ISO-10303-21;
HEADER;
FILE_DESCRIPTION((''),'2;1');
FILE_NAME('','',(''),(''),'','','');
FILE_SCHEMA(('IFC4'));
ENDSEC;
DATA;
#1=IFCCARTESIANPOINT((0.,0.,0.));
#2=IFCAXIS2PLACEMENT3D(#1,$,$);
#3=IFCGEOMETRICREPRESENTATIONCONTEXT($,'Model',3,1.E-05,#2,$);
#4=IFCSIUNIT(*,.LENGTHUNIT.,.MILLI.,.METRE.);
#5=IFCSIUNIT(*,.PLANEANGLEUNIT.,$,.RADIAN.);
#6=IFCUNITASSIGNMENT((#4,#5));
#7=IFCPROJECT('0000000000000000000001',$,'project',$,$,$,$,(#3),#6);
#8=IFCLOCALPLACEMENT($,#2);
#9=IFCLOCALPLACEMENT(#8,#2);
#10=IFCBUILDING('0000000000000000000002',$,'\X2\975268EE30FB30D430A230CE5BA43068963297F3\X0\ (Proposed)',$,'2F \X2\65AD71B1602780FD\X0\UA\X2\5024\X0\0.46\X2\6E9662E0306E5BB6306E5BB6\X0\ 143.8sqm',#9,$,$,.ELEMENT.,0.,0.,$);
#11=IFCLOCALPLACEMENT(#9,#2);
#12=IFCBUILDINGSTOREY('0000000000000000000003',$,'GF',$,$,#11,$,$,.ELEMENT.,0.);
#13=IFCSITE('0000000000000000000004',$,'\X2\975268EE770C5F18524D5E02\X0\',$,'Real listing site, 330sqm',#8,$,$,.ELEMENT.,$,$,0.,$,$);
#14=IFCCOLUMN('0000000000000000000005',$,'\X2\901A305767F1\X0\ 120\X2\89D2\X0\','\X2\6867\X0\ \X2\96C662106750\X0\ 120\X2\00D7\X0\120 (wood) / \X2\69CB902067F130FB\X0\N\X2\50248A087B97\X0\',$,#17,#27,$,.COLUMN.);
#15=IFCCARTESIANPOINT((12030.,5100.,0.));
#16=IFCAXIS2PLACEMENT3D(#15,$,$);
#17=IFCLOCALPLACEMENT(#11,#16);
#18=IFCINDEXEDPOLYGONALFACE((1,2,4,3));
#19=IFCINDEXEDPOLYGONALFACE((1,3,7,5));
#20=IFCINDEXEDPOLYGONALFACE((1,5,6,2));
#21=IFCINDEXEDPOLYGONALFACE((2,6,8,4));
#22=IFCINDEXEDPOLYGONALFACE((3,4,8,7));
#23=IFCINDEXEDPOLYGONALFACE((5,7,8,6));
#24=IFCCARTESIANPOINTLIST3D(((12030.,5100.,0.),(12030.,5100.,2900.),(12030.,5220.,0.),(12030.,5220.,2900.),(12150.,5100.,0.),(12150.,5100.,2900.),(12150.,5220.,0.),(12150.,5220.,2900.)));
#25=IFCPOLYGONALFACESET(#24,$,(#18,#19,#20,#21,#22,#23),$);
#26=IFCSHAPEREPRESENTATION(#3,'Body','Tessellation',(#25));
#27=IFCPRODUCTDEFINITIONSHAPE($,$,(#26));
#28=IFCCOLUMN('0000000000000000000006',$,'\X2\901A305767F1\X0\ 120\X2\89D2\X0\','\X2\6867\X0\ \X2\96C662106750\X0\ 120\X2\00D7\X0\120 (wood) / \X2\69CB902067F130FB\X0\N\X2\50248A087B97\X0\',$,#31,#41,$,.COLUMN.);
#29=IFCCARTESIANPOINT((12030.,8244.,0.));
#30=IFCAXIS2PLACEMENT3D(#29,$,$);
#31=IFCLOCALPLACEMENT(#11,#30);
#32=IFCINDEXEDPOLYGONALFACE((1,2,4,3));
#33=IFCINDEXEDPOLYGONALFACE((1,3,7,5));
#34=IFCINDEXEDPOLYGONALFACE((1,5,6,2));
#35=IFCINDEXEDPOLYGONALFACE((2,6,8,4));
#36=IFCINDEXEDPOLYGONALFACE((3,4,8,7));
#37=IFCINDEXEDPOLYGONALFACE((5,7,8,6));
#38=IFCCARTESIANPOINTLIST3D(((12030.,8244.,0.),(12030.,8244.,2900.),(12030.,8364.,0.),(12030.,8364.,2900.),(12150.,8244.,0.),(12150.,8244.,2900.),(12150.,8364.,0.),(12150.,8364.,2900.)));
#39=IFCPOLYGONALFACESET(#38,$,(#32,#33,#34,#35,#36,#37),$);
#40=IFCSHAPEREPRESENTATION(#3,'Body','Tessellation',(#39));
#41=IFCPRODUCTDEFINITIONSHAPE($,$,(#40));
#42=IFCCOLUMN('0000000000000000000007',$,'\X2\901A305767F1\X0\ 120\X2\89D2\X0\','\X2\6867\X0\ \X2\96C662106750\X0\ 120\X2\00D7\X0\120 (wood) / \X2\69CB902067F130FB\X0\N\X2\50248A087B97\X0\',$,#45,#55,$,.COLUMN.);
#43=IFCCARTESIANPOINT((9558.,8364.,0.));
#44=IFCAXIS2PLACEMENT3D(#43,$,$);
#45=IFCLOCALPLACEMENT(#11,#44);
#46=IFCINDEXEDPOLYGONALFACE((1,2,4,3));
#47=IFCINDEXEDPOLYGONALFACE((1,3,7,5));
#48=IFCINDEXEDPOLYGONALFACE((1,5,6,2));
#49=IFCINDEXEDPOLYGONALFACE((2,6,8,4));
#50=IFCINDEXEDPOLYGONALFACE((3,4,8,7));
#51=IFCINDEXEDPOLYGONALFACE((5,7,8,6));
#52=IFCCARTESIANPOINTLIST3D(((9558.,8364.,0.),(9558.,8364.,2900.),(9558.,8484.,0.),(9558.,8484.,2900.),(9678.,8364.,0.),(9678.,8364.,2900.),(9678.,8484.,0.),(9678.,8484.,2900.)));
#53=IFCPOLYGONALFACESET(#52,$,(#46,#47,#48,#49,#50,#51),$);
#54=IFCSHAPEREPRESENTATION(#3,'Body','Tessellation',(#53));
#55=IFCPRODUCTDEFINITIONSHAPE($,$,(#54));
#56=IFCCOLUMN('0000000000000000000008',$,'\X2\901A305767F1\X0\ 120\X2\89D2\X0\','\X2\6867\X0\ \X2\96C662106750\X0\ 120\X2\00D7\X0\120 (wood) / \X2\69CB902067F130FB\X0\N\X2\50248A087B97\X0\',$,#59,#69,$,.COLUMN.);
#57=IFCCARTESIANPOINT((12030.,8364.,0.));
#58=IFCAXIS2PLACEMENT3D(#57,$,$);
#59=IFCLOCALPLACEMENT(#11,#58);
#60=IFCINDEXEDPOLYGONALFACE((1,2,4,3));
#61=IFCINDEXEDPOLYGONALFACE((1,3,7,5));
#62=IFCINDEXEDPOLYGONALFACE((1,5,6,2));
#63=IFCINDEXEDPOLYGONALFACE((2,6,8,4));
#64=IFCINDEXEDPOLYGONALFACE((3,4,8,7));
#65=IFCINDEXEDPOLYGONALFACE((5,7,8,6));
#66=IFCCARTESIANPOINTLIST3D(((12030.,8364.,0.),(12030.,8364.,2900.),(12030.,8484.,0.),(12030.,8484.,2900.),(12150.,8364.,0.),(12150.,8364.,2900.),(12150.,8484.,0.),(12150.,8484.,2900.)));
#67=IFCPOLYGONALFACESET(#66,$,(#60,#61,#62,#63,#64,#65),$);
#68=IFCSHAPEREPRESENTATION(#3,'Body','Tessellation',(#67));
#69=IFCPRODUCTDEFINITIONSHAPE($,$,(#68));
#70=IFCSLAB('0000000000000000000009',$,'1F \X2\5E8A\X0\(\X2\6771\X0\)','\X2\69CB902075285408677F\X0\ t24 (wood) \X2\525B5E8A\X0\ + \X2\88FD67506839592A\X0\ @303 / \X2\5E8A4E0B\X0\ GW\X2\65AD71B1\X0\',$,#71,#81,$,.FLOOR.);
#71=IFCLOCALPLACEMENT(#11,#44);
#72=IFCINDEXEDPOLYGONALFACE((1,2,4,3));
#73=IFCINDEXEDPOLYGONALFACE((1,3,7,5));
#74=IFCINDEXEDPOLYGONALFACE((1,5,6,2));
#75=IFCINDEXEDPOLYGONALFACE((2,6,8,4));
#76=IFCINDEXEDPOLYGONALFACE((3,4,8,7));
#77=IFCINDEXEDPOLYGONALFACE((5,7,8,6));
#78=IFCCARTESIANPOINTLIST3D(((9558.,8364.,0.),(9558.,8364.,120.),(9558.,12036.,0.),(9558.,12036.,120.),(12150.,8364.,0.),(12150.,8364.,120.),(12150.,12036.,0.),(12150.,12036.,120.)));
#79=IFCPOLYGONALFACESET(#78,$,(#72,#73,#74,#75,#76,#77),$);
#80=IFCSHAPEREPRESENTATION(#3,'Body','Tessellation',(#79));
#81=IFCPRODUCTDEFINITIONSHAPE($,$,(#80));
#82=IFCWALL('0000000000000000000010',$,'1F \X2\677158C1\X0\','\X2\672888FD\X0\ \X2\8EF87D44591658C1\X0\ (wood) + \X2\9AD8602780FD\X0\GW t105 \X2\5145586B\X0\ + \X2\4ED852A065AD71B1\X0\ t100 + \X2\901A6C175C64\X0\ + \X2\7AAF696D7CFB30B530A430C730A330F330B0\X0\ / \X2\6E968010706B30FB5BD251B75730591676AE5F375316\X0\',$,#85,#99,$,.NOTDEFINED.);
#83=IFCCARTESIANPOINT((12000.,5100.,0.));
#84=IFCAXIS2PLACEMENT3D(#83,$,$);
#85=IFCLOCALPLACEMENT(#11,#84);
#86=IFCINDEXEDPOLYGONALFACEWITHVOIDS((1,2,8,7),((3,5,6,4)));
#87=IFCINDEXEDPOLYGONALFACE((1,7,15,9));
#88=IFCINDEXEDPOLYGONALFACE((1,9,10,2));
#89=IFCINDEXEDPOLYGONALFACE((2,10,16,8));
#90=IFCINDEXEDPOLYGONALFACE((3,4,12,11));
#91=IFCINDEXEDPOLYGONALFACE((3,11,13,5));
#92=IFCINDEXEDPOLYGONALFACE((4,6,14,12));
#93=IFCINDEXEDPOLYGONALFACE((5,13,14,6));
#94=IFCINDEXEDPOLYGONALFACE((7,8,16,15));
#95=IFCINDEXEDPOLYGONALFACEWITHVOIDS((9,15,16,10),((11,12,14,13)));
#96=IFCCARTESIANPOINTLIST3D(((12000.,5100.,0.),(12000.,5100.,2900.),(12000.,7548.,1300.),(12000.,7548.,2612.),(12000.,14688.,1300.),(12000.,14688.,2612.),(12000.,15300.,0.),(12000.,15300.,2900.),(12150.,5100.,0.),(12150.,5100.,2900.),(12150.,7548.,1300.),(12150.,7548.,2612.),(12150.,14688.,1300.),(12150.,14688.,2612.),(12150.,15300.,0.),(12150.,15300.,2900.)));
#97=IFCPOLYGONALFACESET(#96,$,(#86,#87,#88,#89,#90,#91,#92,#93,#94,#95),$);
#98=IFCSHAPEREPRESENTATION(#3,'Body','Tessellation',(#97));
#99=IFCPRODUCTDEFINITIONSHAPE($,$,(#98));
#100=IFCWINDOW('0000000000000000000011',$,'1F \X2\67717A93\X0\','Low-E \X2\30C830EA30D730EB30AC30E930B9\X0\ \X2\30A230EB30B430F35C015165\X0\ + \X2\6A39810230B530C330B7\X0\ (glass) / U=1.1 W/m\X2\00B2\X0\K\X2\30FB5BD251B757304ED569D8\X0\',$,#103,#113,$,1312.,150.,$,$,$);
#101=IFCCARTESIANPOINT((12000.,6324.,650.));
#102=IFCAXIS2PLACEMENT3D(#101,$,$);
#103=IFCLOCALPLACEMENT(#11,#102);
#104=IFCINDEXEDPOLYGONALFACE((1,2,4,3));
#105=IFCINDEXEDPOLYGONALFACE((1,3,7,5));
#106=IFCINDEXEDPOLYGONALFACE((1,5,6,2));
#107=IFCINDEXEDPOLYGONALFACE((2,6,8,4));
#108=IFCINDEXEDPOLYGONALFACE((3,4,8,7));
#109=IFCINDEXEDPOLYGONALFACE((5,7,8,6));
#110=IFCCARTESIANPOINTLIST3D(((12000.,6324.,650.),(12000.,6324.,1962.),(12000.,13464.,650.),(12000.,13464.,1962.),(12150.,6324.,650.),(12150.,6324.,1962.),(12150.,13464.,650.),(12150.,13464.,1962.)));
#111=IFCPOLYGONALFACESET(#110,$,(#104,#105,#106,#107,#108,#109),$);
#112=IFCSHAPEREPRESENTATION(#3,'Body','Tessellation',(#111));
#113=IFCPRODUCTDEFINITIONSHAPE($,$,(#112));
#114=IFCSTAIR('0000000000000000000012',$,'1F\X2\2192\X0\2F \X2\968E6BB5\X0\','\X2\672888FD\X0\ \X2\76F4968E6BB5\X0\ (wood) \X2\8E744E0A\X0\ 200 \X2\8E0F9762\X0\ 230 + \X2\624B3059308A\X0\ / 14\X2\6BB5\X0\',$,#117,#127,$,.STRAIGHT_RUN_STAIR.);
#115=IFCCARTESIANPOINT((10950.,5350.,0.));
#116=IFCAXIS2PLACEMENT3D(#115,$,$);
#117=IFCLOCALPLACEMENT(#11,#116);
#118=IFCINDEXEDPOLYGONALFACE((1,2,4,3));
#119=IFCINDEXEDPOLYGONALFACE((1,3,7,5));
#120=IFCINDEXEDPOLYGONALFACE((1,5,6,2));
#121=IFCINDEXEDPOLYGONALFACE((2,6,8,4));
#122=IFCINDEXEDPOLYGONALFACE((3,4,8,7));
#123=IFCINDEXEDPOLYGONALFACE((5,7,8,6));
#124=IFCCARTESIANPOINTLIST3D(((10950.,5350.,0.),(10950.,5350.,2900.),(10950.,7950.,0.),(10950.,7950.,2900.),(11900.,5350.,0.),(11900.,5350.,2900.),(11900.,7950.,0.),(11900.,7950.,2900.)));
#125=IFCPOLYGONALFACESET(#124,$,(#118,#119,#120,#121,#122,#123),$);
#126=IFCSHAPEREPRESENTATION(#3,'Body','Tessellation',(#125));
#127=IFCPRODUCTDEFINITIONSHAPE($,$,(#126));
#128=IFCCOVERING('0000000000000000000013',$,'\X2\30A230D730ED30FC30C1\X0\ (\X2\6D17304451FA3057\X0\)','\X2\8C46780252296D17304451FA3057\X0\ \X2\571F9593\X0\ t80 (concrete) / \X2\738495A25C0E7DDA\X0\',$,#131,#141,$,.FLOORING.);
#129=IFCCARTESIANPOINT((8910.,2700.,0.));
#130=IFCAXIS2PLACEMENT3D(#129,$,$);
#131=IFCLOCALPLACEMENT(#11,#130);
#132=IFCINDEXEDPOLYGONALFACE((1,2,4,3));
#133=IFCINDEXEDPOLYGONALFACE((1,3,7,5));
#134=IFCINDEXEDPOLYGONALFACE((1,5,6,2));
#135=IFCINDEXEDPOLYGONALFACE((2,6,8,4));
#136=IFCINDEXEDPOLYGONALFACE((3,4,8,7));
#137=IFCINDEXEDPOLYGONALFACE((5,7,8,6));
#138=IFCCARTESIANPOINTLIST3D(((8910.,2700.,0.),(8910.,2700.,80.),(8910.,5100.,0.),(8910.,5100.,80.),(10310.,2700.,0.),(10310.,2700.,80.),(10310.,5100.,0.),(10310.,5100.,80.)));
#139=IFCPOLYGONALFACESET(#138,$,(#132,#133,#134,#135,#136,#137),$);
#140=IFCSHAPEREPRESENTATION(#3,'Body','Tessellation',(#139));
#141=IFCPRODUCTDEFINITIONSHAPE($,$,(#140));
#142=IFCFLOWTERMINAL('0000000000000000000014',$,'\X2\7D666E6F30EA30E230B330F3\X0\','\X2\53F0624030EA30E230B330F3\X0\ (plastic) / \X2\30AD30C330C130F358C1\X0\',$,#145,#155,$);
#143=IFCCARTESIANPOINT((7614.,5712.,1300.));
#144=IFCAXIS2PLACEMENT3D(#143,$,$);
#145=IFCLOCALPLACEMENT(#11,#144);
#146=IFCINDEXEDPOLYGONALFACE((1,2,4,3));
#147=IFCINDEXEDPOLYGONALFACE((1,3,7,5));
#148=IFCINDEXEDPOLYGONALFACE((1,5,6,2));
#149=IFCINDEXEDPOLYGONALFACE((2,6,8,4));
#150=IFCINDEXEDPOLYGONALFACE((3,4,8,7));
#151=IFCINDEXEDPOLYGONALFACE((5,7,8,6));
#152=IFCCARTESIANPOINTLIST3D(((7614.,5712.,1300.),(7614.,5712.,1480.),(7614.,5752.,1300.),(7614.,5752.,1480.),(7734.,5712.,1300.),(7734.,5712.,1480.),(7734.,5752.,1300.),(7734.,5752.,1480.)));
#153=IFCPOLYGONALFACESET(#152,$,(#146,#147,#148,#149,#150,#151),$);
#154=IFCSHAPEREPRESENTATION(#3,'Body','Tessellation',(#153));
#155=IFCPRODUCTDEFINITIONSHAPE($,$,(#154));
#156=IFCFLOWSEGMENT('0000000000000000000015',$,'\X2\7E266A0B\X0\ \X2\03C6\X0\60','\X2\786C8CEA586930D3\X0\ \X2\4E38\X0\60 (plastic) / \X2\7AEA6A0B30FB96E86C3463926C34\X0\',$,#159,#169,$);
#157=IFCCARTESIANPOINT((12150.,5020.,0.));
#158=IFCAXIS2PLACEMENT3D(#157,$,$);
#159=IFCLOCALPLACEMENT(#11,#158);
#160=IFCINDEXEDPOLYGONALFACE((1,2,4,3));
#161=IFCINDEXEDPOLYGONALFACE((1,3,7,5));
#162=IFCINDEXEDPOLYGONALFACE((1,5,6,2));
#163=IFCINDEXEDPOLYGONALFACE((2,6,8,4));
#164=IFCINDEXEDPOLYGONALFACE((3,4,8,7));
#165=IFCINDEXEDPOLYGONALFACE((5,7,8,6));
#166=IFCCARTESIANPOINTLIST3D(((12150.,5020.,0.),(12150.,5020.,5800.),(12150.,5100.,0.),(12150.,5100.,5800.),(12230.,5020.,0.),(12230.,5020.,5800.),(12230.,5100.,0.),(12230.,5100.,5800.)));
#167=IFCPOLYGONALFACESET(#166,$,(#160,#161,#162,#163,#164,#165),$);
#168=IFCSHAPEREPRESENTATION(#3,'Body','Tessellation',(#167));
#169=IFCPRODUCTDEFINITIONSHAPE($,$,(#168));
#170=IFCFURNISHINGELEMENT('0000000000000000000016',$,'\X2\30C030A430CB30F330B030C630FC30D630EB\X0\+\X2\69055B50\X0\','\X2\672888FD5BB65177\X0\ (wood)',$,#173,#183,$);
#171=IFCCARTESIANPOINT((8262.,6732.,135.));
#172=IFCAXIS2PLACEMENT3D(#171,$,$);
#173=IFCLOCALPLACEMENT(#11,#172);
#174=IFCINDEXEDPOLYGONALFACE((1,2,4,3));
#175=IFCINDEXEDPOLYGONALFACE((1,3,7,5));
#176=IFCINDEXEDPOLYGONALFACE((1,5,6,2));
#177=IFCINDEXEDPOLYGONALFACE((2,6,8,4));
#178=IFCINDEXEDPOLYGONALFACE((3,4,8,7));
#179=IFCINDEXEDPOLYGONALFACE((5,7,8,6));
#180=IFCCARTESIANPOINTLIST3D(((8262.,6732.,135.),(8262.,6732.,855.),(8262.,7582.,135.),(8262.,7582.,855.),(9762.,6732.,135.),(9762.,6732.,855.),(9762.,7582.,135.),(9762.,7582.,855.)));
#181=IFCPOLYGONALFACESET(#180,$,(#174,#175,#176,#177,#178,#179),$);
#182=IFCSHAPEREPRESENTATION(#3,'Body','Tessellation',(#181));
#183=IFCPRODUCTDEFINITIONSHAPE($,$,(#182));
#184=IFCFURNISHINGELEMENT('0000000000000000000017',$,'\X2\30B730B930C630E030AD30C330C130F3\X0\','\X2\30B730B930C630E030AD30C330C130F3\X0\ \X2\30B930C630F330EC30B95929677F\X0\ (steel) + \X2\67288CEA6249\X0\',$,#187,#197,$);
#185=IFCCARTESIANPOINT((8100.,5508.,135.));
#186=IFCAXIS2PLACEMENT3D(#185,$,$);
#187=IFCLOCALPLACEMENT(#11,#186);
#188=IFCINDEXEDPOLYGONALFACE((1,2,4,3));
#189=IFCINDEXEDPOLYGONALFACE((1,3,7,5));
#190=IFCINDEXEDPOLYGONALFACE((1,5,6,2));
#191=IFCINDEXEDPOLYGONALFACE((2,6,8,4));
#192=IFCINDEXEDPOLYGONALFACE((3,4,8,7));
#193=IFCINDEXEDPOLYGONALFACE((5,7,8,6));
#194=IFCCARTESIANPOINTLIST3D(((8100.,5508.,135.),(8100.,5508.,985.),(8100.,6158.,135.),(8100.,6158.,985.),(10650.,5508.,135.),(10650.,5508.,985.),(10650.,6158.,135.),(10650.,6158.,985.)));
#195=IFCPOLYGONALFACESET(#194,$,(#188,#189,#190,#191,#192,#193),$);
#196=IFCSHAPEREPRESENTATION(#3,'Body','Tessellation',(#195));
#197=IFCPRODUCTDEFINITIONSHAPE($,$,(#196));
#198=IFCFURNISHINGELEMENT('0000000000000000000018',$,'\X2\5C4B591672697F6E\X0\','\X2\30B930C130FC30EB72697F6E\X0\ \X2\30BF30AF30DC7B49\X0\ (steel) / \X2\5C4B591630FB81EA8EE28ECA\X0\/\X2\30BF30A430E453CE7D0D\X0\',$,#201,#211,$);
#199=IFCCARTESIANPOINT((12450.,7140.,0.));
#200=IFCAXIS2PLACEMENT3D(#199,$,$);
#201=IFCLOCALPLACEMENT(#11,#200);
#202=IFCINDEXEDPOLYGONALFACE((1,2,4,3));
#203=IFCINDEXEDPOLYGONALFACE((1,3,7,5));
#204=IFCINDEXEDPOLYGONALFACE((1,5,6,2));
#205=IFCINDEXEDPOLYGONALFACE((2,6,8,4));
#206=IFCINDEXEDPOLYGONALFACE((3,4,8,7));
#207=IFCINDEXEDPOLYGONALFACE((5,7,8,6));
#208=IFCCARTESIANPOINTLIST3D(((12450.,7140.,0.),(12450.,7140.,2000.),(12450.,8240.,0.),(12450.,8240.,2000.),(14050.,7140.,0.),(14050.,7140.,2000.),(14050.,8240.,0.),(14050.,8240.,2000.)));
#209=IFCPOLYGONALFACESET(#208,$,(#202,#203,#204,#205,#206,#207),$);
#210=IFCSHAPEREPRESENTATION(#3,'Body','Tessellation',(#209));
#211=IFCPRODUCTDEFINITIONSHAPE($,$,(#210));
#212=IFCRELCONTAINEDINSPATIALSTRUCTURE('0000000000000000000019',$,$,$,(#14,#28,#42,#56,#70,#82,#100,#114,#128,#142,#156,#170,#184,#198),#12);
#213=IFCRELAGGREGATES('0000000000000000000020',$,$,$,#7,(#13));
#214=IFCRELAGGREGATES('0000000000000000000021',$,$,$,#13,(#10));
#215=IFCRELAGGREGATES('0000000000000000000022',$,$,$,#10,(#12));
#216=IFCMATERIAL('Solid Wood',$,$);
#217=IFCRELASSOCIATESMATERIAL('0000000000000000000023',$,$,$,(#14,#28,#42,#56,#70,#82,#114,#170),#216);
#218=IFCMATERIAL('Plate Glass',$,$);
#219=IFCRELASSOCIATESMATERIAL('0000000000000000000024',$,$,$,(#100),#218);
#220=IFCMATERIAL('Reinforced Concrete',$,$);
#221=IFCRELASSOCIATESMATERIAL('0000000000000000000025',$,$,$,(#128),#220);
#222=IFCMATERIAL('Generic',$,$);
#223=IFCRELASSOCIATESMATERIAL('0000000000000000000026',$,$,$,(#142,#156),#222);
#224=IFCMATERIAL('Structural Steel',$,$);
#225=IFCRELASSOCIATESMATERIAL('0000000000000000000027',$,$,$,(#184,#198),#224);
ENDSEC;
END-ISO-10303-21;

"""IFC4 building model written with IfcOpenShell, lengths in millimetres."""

from ifc_helpers import new_model, si_unit, frame, frame_2d, origin, place, context, project, spatial, rectangle, extrude, material, element, fill, save


model = new_model("IFC4")

# Units and contexts
model_context = context("Model", 3, precision=1e-05, world=origin())
ifc_project = project(units=[si_unit("LENGTHUNIT", "METRE", prefix="MILLI"), si_unit("PLANEANGLEUNIT", "RADIAN")], contexts=[model_context])

# Site, building, storey
site_placement = place(None, origin())
site = spatial("IfcSite", under=ifc_project, at=site_placement, Name="青森県弘前市", ObjectType="Real listing site, 330sqm", CompositionType="ELEMENT", RefElevation=0.0)
building_placement = place(site_placement, origin())
building = spatial("IfcBuilding", under=site, at=building_placement, Name="青森・ピアノ室と防音 (Proposed)", ObjectType="2F 断熱性能UA値0.46準拠の家の家 143.8sqm", CompositionType="ELEMENT", ElevationOfRefHeight=0.0, ElevationOfTerrain=0.0)
storey_placement = place(building_placement, origin())
storey = spatial("IfcBuildingStorey", under=building, at=storey_placement, Name="GF", CompositionType="ELEMENT", Elevation=0.0)

# Columns
ifc_material_1 = material(Name="Solid Wood")
column_1_placement = place(storey_placement, frame((12030.0, 5100.0, 0.0)))
element("IfcColumn", 1, at=column_1_placement, inside=storey, material=ifc_material_1, Name="通し柱 120角", Description="桧 集成材 120×120 (wood) / 構造柱・N値計算", PredefinedType="COLUMN", context=model_context, shape_type="SweptSolid", body=[
    extrude(rectangle(XDim=120.0, YDim=120.0, at=frame_2d((60.0, 60.0))), frame((12030.0, 5100.0, 0.0)), (0.0, 0.0, 1.0), 2900.0),
])
column_2_placement = place(storey_placement, frame((12030.0, 8244.0, 0.0)))
element("IfcColumn", 2, at=column_2_placement, inside=storey, material=ifc_material_1, Name="通し柱 120角", Description="桧 集成材 120×120 (wood) / 構造柱・N値計算", PredefinedType="COLUMN", context=model_context, shape_type="SweptSolid", body=[
    extrude(rectangle(XDim=120.0, YDim=120.0, at=frame_2d((60.0, 60.0))), frame((12030.0, 8244.0, 0.0)), (0.0, 0.0, 1.0), 2900.0),
])
column_3_placement = place(storey_placement, frame((9558.0, 8364.0, 0.0)))
element("IfcColumn", 3, at=column_3_placement, inside=storey, material=ifc_material_1, Name="通し柱 120角", Description="桧 集成材 120×120 (wood) / 構造柱・N値計算", PredefinedType="COLUMN", context=model_context, shape_type="SweptSolid", body=[
    extrude(rectangle(XDim=120.0, YDim=120.0, at=frame_2d((60.0, 60.0))), frame((9558.0, 8364.0, 0.0)), (0.0, 0.0, 1.0), 2900.0),
])
column_4_placement = place(storey_placement, frame((12030.0, 8364.0, 0.0)))
element("IfcColumn", 4, at=column_4_placement, inside=storey, material=ifc_material_1, Name="通し柱 120角", Description="桧 集成材 120×120 (wood) / 構造柱・N値計算", PredefinedType="COLUMN", context=model_context, shape_type="SweptSolid", body=[
    extrude(rectangle(XDim=120.0, YDim=120.0, at=frame_2d((60.0, 60.0))), frame((12030.0, 8364.0, 0.0)), (0.0, 0.0, 1.0), 2900.0),
])

# Slab
slab_placement = place(storey_placement, frame((9558.0, 8364.0, 0.0)))
element("IfcSlab", 5, at=slab_placement, inside=storey, material=ifc_material_1, Name="1F 床(東)", Description="構造用合板 t24 (wood) 剛床 + 製材根太 @303 / 床下 GW断熱", PredefinedType="FLOOR", context=model_context, shape_type="SweptSolid", body=[
    extrude(rectangle(XDim=2592.0, YDim=3672.0, at=frame_2d((1296.0, 1836.0))), frame((9558.0, 8364.0, 0.0)), (0.0, 0.0, 1.0), 120.0),
])

# Wall, opening, window
wall_1_placement = place(storey_placement, frame((12000.0, 5100.0, 0.0)))
wall_1 = element("IfcWall", 6, at=wall_1_placement, inside=storey, material=ifc_material_1, Name="1F 東壁", Description="木製 軸組外壁 (wood) + 高性能GW t105 充填 + 付加断熱 t100 + 通気層 + 窯業系サイディング / 準耐火・寒冷地外皮強化", PredefinedType="NOTDEFINED", context=model_context, shape_type="SweptSolid", body=[
    extrude(rectangle(XDim=150.0, YDim=10200.0, at=frame_2d((75.0, 5100.0))), frame((12000.0, 5100.0, 0.0)), (0.0, 0.0, 1.0), 2900.0),
])
opening_placement = place(storey_placement, frame((12000.0, 6324.0, 650.0)))
opening = element("IfcOpeningElement", 7, at=opening_placement, cuts=wall_1, PredefinedType="NOTDEFINED", context=model_context, shape_type="SweptSolid", body=[
    extrude(rectangle(XDim=150.0, YDim=7140.0, at=frame_2d((75.0, 3570.0))), frame((12000.0, 6324.0, 650.0)), (0.0, 0.0, 1.0), 1312.0),
])
ifc_material_2 = material(Name="Plate Glass")
window_placement = place(storey_placement, frame((12000.0, 6324.0, 650.0)))
window = element("IfcWindow", 8, at=window_placement, inside=storey, material=ifc_material_2, Name="1F 東窓", Description="Low-E トリプルガラス アルゴン封入 + 樹脂サッシ (glass) / U=1.1 W/m²K・寒冷地仕様", OverallHeight=1312.0, OverallWidth=150.0, context=model_context, shape_type="SweptSolid", body=[
    extrude(rectangle(XDim=150.0, YDim=7140.0, at=frame_2d((75.0, 3570.0))), frame((12000.0, 6324.0, 650.0)), (0.0, 0.0, 1.0), 1312.0),
])
fill(opening, window)

# Stair
stair_placement = place(storey_placement, frame((10950.0, 5350.0, 0.0)))
element("IfcStair", 9, at=stair_placement, inside=storey, material=ifc_material_1, Name="1F→2F 階段", Description="木製 直階段 (wood) 蹴上 200 踏面 230 + 手すり / 14段", PredefinedType="STRAIGHT_RUN_STAIR", context=model_context, shape_type="SweptSolid", body=[
    extrude(rectangle(XDim=950.0, YDim=2600.0, at=frame_2d((475.0, 1300.0))), frame((10950.0, 5350.0, 0.0)), (0.0, 0.0, 1.0), 2900.0),
])

# Covering
ifc_material_3 = material(Name="Reinforced Concrete")
covering_placement = place(storey_placement, frame((8910.0, 2700.0, 0.0)))
element("IfcCovering", 10, at=covering_placement, inside=storey, material=ifc_material_3, Name="アプローチ (洗い出し)", Description="豆砂利洗い出し 土間 t80 (concrete) / 玄関導線", PredefinedType="FLOORING", context=model_context, shape_type="SweptSolid", body=[
    extrude(rectangle(XDim=1400.0, YDim=2400.0, at=frame_2d((700.0, 1200.0))), frame((8910.0, 2700.0, 0.0)), (0.0, 0.0, 1.0), 80.0),
])

# Flow terminal
ifc_material_4 = material(Name="Generic")
flow_terminal_placement = place(storey_placement, frame((7614.0, 5712.0, 1300.0)))
element("IfcFlowTerminal", 11, at=flow_terminal_placement, inside=storey, material=ifc_material_4, Name="給湯リモコン", Description="台所リモコン (plastic) / キッチン壁", context=model_context, shape_type="SweptSolid", body=[
    extrude(rectangle(XDim=120.0, YDim=40.0, at=frame_2d((60.0, 20.0))), frame((7614.0, 5712.0, 1300.0)), (0.0, 0.0, 1.0), 180.0),
])

# Flow segment
flow_segment_placement = place(storey_placement, frame((12150.0, 5020.0, 0.0)))
element("IfcFlowSegment", 12, at=flow_segment_placement, inside=storey, material=ifc_material_4, Name="縦樋 φ60", Description="硬質塩ビ 丸60 (plastic) / 竪樋・雨水排水", context=model_context, shape_type="SweptSolid", body=[
    extrude(rectangle(XDim=80.0, YDim=80.0, at=frame_2d((40.0, 40.0))), frame((12150.0, 5020.0, 0.0)), (0.0, 0.0, 1.0), 5800.0),
])

# Furnishing elements
furnishing_1_placement = place(storey_placement, frame((8262.0, 6732.0, 135.0)))
element("IfcFurnishingElement", 13, at=furnishing_1_placement, inside=storey, material=ifc_material_1, Name="ダイニングテーブル+椅子", Description="木製家具 (wood)", context=model_context, shape_type="SweptSolid", body=[
    extrude(rectangle(XDim=1500.0, YDim=850.0, at=frame_2d((750.0, 425.0))), frame((8262.0, 6732.0, 135.0)), (0.0, 0.0, 1.0), 720.0),
])
ifc_material_5 = material(Name="Structural Steel")
furnishing_2_placement = place(storey_placement, frame((8100.0, 5508.0, 135.0)))
element("IfcFurnishingElement", 14, at=furnishing_2_placement, inside=storey, material=ifc_material_5, Name="システムキッチン", Description="システムキッチン ステンレス天板 (steel) + 木質扉", context=model_context, shape_type="SweptSolid", body=[
    extrude(rectangle(XDim=2550.0, YDim=650.0, at=frame_2d((1275.0, 325.0))), frame((8100.0, 5508.0, 135.0)), (0.0, 0.0, 1.0), 850.0),
])
furnishing_3_placement = place(storey_placement, frame((12450.0, 7140.0, 0.0)))
element("IfcFurnishingElement", 15, at=furnishing_3_placement, inside=storey, material=ifc_material_5, Name="屋外物置", Description="スチール物置 タクボ等 (steel) / 屋外・自転車/タイヤ収納", context=model_context, shape_type="SweptSolid", body=[
    extrude(rectangle(XDim=1600.0, YDim=1100.0, at=frame_2d((800.0, 550.0))), frame((12450.0, 7140.0, 0.0)), (0.0, 0.0, 1.0), 2000.0),
])

save(model, "model.ifc")
